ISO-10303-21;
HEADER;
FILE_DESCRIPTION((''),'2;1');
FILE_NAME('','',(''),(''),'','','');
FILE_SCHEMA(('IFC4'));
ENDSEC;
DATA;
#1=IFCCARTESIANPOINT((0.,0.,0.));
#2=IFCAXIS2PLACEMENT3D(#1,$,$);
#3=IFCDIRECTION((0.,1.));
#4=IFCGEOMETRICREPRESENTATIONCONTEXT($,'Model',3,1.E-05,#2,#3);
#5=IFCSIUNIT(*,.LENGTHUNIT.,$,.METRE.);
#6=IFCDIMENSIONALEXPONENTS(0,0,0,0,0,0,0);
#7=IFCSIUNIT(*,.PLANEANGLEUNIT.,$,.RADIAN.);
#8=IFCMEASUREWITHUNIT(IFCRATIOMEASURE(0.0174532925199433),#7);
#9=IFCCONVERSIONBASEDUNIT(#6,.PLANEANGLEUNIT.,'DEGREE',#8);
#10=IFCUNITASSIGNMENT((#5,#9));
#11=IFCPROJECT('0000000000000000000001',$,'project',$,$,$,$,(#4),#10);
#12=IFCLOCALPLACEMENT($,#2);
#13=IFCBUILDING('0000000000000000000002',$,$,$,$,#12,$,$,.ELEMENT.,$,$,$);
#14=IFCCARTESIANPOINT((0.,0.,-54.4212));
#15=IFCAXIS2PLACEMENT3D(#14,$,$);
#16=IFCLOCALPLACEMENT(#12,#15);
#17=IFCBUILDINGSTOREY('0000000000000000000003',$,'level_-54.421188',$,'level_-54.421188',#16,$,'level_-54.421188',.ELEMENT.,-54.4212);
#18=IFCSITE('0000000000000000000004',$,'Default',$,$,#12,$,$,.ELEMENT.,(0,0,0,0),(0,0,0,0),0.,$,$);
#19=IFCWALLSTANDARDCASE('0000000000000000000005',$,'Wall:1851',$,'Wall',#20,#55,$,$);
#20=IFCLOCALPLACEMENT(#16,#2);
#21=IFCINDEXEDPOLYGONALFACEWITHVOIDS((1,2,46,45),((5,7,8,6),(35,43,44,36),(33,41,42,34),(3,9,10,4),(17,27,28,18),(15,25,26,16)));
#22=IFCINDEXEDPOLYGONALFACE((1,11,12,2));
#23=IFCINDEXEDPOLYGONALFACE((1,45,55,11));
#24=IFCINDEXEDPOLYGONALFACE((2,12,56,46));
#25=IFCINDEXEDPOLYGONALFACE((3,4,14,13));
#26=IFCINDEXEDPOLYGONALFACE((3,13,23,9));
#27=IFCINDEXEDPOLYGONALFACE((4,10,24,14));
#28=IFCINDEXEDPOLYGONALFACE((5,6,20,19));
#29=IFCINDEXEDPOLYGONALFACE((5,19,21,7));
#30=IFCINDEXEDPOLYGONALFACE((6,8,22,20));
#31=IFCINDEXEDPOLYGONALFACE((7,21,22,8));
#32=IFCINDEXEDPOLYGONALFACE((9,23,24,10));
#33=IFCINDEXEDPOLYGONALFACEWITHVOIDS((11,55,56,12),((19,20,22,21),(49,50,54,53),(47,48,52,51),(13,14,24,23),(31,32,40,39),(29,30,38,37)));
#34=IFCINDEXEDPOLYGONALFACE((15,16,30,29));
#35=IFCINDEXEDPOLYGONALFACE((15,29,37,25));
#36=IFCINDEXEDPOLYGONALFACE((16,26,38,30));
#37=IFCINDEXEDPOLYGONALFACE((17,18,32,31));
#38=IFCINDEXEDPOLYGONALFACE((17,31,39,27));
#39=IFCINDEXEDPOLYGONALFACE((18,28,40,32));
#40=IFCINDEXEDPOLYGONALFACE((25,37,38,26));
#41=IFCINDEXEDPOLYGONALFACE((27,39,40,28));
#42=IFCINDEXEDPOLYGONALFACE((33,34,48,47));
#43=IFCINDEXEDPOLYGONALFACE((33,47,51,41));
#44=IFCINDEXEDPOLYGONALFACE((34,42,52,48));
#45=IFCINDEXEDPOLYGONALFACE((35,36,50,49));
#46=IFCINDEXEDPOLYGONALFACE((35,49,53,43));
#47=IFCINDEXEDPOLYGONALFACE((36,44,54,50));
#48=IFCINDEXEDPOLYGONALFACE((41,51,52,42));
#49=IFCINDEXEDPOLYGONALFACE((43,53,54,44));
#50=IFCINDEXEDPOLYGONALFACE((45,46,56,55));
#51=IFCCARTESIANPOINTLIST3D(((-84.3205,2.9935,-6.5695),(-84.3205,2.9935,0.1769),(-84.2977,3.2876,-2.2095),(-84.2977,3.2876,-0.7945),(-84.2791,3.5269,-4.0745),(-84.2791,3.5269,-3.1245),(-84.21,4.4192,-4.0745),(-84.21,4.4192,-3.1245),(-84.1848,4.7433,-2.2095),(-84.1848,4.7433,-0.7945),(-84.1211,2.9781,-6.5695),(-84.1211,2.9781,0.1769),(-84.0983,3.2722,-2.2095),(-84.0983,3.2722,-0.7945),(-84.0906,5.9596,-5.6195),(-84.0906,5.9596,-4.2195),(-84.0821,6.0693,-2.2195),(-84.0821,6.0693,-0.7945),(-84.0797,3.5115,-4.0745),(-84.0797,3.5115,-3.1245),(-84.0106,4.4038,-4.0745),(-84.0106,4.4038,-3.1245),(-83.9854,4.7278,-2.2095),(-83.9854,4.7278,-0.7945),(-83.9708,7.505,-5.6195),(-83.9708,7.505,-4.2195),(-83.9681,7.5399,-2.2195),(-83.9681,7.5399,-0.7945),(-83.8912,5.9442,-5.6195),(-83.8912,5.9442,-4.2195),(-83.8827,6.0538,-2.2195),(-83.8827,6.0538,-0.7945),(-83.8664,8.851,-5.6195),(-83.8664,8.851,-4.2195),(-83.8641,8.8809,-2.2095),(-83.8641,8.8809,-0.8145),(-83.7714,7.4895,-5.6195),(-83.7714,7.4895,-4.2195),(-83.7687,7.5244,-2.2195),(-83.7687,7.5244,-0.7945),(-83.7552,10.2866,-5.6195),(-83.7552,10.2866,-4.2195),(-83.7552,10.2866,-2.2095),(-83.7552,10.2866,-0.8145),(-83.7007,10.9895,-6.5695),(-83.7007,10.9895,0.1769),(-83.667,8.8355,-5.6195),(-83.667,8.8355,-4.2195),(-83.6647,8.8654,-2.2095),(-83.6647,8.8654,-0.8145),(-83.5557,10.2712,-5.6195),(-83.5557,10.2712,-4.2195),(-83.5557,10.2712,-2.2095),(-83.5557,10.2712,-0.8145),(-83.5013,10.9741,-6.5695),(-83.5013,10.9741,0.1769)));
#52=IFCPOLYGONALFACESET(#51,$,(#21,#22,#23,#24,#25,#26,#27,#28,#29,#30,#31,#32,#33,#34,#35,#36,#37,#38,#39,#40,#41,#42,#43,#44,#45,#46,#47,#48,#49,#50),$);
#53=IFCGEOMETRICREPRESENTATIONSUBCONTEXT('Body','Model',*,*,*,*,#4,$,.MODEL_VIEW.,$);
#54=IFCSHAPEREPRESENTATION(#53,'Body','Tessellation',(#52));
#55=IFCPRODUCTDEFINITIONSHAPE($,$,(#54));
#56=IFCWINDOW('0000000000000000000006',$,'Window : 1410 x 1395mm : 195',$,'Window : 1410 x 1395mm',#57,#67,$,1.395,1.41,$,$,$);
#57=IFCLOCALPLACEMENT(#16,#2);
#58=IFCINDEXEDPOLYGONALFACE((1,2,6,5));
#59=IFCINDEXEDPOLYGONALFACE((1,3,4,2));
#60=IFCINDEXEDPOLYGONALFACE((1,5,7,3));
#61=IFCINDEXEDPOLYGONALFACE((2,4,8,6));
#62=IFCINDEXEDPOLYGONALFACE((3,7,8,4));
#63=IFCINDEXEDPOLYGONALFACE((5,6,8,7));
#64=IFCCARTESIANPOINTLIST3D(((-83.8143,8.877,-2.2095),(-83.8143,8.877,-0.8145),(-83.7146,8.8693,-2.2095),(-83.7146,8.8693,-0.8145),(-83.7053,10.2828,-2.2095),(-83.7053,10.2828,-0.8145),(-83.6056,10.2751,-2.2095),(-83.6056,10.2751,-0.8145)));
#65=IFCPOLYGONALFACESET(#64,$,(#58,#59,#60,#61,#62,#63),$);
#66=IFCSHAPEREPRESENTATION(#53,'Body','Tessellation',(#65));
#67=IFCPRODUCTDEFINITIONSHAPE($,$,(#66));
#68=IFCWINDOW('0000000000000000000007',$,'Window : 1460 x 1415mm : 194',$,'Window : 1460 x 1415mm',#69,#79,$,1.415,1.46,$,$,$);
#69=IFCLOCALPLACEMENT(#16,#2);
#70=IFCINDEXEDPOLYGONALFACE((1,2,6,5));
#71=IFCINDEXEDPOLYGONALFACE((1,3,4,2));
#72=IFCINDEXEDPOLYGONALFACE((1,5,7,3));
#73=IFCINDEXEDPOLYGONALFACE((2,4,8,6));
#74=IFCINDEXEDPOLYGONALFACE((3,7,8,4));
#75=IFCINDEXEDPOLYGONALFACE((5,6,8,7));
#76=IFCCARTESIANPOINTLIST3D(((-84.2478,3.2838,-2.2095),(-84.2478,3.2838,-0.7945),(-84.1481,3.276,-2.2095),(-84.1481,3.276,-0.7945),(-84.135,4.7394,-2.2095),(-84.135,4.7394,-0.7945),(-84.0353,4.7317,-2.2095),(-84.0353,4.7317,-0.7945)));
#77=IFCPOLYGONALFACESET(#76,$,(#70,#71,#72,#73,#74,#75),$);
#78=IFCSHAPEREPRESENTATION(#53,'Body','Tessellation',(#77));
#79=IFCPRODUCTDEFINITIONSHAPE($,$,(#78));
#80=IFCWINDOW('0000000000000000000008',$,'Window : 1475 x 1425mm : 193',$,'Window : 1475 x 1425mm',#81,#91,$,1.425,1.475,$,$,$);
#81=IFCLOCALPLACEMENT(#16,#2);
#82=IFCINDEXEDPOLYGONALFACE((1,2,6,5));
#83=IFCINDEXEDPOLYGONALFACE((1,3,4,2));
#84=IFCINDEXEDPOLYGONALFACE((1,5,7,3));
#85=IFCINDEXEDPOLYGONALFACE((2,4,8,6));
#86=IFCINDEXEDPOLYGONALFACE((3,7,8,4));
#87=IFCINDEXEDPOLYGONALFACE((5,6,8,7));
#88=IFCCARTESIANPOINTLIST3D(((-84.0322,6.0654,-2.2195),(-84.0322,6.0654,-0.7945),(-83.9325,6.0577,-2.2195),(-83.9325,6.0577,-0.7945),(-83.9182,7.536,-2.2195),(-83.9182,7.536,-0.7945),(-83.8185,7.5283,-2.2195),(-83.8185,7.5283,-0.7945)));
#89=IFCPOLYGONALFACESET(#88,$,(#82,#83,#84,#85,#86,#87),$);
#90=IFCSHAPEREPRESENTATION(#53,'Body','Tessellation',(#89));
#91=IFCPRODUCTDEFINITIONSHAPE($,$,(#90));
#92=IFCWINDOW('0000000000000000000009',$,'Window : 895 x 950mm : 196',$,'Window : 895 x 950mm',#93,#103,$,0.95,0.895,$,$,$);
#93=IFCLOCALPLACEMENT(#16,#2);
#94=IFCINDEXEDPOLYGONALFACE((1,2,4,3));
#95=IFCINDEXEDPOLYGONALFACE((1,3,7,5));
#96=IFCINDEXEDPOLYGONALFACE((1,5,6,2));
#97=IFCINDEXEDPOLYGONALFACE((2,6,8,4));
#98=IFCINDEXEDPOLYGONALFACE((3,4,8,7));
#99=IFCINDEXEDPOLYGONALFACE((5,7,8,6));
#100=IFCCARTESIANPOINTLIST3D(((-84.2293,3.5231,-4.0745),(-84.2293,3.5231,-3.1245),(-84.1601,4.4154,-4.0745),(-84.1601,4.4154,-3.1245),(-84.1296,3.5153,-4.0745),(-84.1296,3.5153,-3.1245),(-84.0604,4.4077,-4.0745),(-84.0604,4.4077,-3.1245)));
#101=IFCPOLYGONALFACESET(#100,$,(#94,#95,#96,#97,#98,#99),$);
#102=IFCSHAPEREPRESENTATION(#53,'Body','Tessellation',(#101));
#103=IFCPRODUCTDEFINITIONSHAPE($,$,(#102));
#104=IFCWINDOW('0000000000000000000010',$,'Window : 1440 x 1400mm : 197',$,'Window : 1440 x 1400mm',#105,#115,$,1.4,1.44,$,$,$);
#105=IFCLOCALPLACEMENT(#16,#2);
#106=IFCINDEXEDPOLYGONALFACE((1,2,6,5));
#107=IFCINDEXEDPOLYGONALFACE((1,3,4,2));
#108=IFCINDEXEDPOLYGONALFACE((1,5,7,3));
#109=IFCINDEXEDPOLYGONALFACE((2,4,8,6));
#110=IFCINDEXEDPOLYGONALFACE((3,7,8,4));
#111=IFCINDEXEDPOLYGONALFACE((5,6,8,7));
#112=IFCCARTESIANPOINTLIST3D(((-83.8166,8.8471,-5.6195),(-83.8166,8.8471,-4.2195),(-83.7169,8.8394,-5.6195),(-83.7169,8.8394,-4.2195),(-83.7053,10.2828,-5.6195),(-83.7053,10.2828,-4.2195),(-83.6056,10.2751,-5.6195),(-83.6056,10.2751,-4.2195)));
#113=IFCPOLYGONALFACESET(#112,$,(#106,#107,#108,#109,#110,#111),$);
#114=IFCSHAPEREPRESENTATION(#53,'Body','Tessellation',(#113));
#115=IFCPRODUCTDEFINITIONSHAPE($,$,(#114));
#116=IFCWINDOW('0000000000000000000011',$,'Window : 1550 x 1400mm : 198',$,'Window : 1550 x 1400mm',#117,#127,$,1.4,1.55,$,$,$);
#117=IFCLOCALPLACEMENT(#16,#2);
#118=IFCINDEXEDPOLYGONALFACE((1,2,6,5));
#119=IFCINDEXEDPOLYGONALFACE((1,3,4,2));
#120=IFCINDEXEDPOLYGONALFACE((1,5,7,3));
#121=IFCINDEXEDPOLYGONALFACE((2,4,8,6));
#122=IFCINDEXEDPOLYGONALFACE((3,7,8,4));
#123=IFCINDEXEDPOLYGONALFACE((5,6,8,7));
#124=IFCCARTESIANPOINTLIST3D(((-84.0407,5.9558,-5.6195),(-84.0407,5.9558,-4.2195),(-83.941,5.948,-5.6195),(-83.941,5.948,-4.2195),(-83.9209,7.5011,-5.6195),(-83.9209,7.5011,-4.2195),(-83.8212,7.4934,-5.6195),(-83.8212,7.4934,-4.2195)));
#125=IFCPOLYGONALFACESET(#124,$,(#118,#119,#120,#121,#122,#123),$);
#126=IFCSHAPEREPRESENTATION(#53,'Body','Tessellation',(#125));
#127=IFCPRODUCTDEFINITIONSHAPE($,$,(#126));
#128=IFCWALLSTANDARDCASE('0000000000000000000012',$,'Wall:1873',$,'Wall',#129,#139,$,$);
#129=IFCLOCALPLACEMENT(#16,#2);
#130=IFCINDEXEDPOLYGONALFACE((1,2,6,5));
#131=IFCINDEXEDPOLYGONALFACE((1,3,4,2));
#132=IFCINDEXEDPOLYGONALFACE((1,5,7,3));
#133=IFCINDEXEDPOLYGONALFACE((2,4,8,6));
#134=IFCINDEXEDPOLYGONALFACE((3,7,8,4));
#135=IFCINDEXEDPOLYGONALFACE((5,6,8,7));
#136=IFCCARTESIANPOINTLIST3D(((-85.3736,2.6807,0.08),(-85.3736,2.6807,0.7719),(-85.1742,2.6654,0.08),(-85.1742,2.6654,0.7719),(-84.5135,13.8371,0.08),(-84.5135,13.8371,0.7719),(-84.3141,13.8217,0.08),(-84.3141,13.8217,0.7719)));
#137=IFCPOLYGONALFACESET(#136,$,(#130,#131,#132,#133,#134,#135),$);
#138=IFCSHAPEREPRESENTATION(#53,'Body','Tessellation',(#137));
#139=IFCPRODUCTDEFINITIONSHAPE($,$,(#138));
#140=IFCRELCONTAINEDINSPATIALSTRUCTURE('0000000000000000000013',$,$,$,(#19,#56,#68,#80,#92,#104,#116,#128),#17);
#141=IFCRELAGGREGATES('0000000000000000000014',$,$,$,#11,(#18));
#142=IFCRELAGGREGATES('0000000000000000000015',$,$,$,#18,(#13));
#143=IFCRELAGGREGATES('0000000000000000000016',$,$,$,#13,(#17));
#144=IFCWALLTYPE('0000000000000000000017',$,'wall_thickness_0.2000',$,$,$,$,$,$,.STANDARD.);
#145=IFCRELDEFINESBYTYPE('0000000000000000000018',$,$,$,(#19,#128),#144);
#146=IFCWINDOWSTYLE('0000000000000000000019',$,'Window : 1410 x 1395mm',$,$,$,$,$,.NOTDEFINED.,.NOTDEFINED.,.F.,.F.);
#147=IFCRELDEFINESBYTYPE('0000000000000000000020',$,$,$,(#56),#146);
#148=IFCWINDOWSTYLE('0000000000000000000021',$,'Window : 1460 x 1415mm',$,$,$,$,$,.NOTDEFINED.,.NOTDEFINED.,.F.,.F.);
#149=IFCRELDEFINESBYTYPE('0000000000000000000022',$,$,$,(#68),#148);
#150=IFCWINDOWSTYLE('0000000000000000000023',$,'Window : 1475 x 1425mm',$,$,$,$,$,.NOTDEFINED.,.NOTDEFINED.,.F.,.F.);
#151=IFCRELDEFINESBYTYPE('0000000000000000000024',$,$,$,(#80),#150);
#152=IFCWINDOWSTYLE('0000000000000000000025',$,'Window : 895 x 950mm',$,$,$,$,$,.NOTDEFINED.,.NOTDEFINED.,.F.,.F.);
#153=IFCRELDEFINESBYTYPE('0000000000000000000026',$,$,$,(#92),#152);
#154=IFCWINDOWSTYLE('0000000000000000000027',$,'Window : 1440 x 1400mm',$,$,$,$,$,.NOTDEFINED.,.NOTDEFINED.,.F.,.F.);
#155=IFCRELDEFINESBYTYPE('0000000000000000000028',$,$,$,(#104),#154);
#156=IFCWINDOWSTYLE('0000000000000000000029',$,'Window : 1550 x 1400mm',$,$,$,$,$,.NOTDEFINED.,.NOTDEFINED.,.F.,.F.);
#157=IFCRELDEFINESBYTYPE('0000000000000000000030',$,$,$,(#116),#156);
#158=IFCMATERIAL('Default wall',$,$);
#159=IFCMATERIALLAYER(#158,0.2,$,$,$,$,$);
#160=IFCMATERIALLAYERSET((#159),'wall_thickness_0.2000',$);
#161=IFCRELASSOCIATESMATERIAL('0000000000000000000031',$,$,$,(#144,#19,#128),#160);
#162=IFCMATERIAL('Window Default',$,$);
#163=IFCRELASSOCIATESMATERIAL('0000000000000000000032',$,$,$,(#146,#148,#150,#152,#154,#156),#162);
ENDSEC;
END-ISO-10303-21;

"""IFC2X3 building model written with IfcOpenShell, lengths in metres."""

from ifc_helpers import new_model, entity, si_unit, converted_unit, direction, frame, frame_2d, origin, origin_2d_with_axis, place, context, subcontext, project, spatial, polyline, rectangle, outline, extrude, source, transform, mapped, material, layer, layer_set, layer_usage, type_object, type_shapes, element, fill, save


model = new_model("IFC2X3")

# Units and contexts
model_context = context("Model", 3, precision=1e-05, world=origin(), true_north=direction((0.0, 1.0)))
body_context = subcontext(model_context, "Body", "Model", "MODEL_VIEW")
ifc_project = project(units=[si_unit("LENGTHUNIT", "METRE"), converted_unit("PLANEANGLEUNIT", "DEGREE", entity("IfcRatioMeasure", 0.0174532925199433), si_unit("PLANEANGLEUNIT", "RADIAN"), dimensions=[0, 0, 0, 0, 0, 0, 0])], contexts=[model_context])

# Site, building, storey
placement_1 = place(None, origin())
site = spatial("IfcSite", under=ifc_project, at=placement_1, Name="Default", CompositionType="ELEMENT", RefLatitude=(0, 0, 0, 0), RefLongitude=(0, 0, 0, 0), RefElevation=0.0)
building = spatial("IfcBuilding", under=site, at=placement_1, CompositionType="ELEMENT")
storey_placement = place(placement_1, frame((0.0, 0.0, -54.4212)))
storey = spatial("IfcBuildingStorey", under=building, at=storey_placement, Name="level_-54.421188", ObjectType="level_-54.421188", LongName="level_-54.421188", CompositionType="ELEMENT", Elevation=-54.4212)

# Shared definitions
ifc_material_1 = material(Name="Default wall")
ifc_layer = layer(ifc_material_1, 0.2)
ifc_layer_set = layer_set([ifc_layer], Name="wall_thickness_0.2000")
ifc_layer_usage = layer_usage(ifc_layer_set, "AXIS2", "POSITIVE", -0.1)
wall_type = type_object("IfcWallType", Name="wall_thickness_0.2000", PredefinedType="STANDARD", material=ifc_layer_set)

# Wall, openings, windows
placement_2 = place(placement_1, frame((0.0, 0.0, -60.9907)))
wall_1_placement = place(placement_2, frame((-83.601, 10.9818, 0.0), z_axis=(0.0, 0.0, 1.0), x_axis=(-0.077281, -0.997009, 0.0)))
wall_1 = element("IfcWallStandardCase", 1, at=wall_1_placement, inside=storey, type_object=wall_type, material=ifc_layer_usage, Name="Wall:1851", ObjectType="Wall", context=body_context, shape_type="SweptSolid", body=[
    extrude(outline(polyline([(8.02, -0.1), (8.02, 0.1), (0.0, 0.1), (0.0, -0.1), (8.02, -0.1)])), origin(), (0.0, 0.0, 1.0), 6.7464),
])
opening_1_placement = place(wall_1_placement, frame((3.46, -0.1, 4.3499)))
opening_1 = element("IfcOpeningElement", 2, at=opening_1_placement, cuts=wall_1, ObjectType="Opening", context=body_context, shape_type="SweptSolid", body=[
    extrude(rectangle(XDim=1.475, YDim=1.425, at=frame_2d((0.7125, 0.7375), x_axis=(0.0, 1.0))), frame((0.0, 0.0, 0.0), z_axis=(0.0, 1.0, 0.0), x_axis=(0.0, 0.0, 1.0)), (0.0, 0.0, 1.0), 0.2),
])
opening_2_placement = place(wall_1_placement, frame((6.265, -0.1, 4.3599)))
opening_2 = element("IfcOpeningElement", 3, at=opening_2_placement, cuts=wall_1, ObjectType="Opening", context=body_context, shape_type="SweptSolid", body=[
    extrude(rectangle(XDim=1.46, YDim=1.415, at=frame_2d((0.7075, 0.73), x_axis=(0.0, 1.0))), frame((0.0, 0.0, 0.0), z_axis=(0.0, 1.0, 0.0), x_axis=(0.0, 0.0, 1.0)), (0.0, 0.0, 1.0), 0.2),
])
opening_3_placement = place(wall_1_placement, frame((0.705, -0.1, 4.3599)))
opening_3 = element("IfcOpeningElement", 4, at=opening_3_placement, cuts=wall_1, ObjectType="Opening", context=body_context, shape_type="SweptSolid", body=[
    extrude(rectangle(XDim=1.41, YDim=1.395, at=frame_2d((0.6975, 0.705), x_axis=(0.0, 1.0))), frame((0.0, 0.0, 0.0), z_axis=(0.0, 1.0, 0.0), x_axis=(0.0, 0.0, 1.0)), (0.0, 0.0, 1.0), 0.2),
])
opening_4_placement = place(wall_1_placement, frame((6.59, -0.1, 2.4949)))
opening_4 = element("IfcOpeningElement", 5, at=opening_4_placement, cuts=wall_1, ObjectType="Opening", context=body_context, shape_type="SweptSolid", body=[
    extrude(rectangle(XDim=0.895, YDim=0.95, at=frame_2d((0.475, 0.4475), x_axis=(0.0, 1.0))), frame((0.0, 0.0, 0.0), z_axis=(0.0, 1.0, 0.0), x_axis=(0.0, 0.0, 1.0)), (0.0, 0.0, 1.0), 0.2),
])
opening_5_placement = place(wall_1_placement, frame((0.705, -0.1, 0.9499)))
opening_5 = element("IfcOpeningElement", 6, at=opening_5_placement, cuts=wall_1, ObjectType="Opening", context=body_context, shape_type="SweptSolid", body=[
    extrude(rectangle(XDim=1.44, YDim=1.4, at=frame_2d((0.7, 0.72), x_axis=(0.0, 1.0))), frame((0.0, 0.0, 0.0), z_axis=(0.0, 1.0, 0.0), x_axis=(0.0, 0.0, 1.0)), (0.0, 0.0, 1.0), 0.2),
])
opening_6_placement = place(wall_1_placement, frame((3.495, -0.1, 0.9499)))
opening_6 = element("IfcOpeningElement", 7, at=opening_6_placement, cuts=wall_1, ObjectType="Opening", context=body_context, shape_type="SweptSolid", body=[
    extrude(rectangle(XDim=1.55, YDim=1.4, at=frame_2d((0.7, 0.775), x_axis=(0.0, 1.0))), frame((0.0, 0.0, 0.0), z_axis=(0.0, 1.0, 0.0), x_axis=(0.0, 0.0, 1.0)), (0.0, 0.0, 1.0), 0.2),
])
ifc_material_2 = material(Name="Window Default")
window_style_1 = type_object("IfcWindowStyle", Name="Window : 1410 x 1395mm", ConstructionType="NOTDEFINED", OperationType="NOTDEFINED", ParameterTakesPrecedence=False, Sizeable=False, material=ifc_material_2)
shared_shape_1 = source(origin(), body_context, "Body", "SweptSolid", [
    extrude(rectangle(XDim=0.1, YDim=1.41, at=origin_2d_with_axis()), frame((0.705, 0.1, 0.0), z_axis=(0.0, 0.0, 1.0), x_axis=(0.0, 1.0, 0.0)), (0.0, 0.0, 1.0), 1.395),
])
type_shapes(window_style_1, [shared_shape_1])
window_1_placement = place(opening_3_placement, origin())
window_1 = element("IfcWindow", 8, at=window_1_placement, inside=storey, type_object=window_style_1, Name="Window : 1410 x 1395mm : 195", ObjectType="Window : 1410 x 1395mm", OverallHeight=1.395, OverallWidth=1.41, context=body_context, shape_type="MappedRepresentation", body=[
    mapped(shared_shape_1, transform((0.0, 0.0, 0.0), scale=1.0)),
])
fill(opening_3, window_1)
window_style_2 = type_object("IfcWindowStyle", Name="Window : 1460 x 1415mm", ConstructionType="NOTDEFINED", OperationType="NOTDEFINED", ParameterTakesPrecedence=False, Sizeable=False, material=ifc_material_2)
shared_shape_2 = source(origin(), body_context, "Body", "SweptSolid", [
    extrude(rectangle(XDim=0.1, YDim=1.46, at=origin_2d_with_axis()), frame((0.73, 0.1, 0.0), z_axis=(0.0, 0.0, 1.0), x_axis=(0.0, 1.0, 0.0)), (0.0, 0.0, 1.0), 1.415),
])
type_shapes(window_style_2, [shared_shape_2])
window_2_placement = place(opening_2_placement, origin())
window_2 = element("IfcWindow", 9, at=window_2_placement, inside=storey, type_object=window_style_2, Name="Window : 1460 x 1415mm : 194", ObjectType="Window : 1460 x 1415mm", OverallHeight=1.415, OverallWidth=1.46, context=body_context, shape_type="MappedRepresentation", body=[
    mapped(shared_shape_2, transform((0.0, 0.0, 0.0), scale=1.0)),
])
fill(opening_2, window_2)
window_style_3 = type_object("IfcWindowStyle", Name="Window : 1475 x 1425mm", ConstructionType="NOTDEFINED", OperationType="NOTDEFINED", ParameterTakesPrecedence=False, Sizeable=False, material=ifc_material_2)
shared_shape_3 = source(origin(), body_context, "Body", "SweptSolid", [
    extrude(rectangle(XDim=0.1, YDim=1.475, at=origin_2d_with_axis()), frame((0.7375, 0.1, 0.0), z_axis=(0.0, 0.0, 1.0), x_axis=(0.0, 1.0, 0.0)), (0.0, 0.0, 1.0), 1.425),
])
type_shapes(window_style_3, [shared_shape_3])
window_3_placement = place(opening_1_placement, origin())
window_3 = element("IfcWindow", 10, at=window_3_placement, inside=storey, type_object=window_style_3, Name="Window : 1475 x 1425mm : 193", ObjectType="Window : 1475 x 1425mm", OverallHeight=1.425, OverallWidth=1.475, context=body_context, shape_type="MappedRepresentation", body=[
    mapped(shared_shape_3, transform((0.0, 0.0, 0.0), scale=1.0)),
])
fill(opening_1, window_3)
window_style_4 = type_object("IfcWindowStyle", Name="Window : 895 x 950mm", ConstructionType="NOTDEFINED", OperationType="NOTDEFINED", ParameterTakesPrecedence=False, Sizeable=False, material=ifc_material_2)
shared_shape_4 = source(origin(), body_context, "Body", "SweptSolid", [
    extrude(rectangle(XDim=0.1, YDim=0.895, at=origin_2d_with_axis()), frame((0.4475, 0.1, 0.0), z_axis=(0.0, 0.0, 1.0), x_axis=(0.0, 1.0, 0.0)), (0.0, 0.0, 1.0), 0.95),
])
type_shapes(window_style_4, [shared_shape_4])
window_4_placement = place(opening_4_placement, origin())
window_4 = element("IfcWindow", 11, at=window_4_placement, inside=storey, type_object=window_style_4, Name="Window : 895 x 950mm : 196", ObjectType="Window : 895 x 950mm", OverallHeight=0.95, OverallWidth=0.895, context=body_context, shape_type="MappedRepresentation", body=[
    mapped(shared_shape_4, transform((0.0, 0.0, 0.0), scale=1.0)),
])
fill(opening_4, window_4)
window_style_5 = type_object("IfcWindowStyle", Name="Window : 1440 x 1400mm", ConstructionType="NOTDEFINED", OperationType="NOTDEFINED", ParameterTakesPrecedence=False, Sizeable=False, material=ifc_material_2)
shared_shape_5 = source(origin(), body_context, "Body", "SweptSolid", [
    extrude(rectangle(XDim=0.1, YDim=1.44, at=origin_2d_with_axis()), frame((0.72, 0.1, 0.0), z_axis=(0.0, 0.0, 1.0), x_axis=(0.0, 1.0, 0.0)), (0.0, 0.0, 1.0), 1.4),
])
type_shapes(window_style_5, [shared_shape_5])
window_5_placement = place(opening_5_placement, origin())
window_5 = element("IfcWindow", 12, at=window_5_placement, inside=storey, type_object=window_style_5, Name="Window : 1440 x 1400mm : 197", ObjectType="Window : 1440 x 1400mm", OverallHeight=1.4, OverallWidth=1.44, context=body_context, shape_type="MappedRepresentation", body=[
    mapped(shared_shape_5, transform((0.0, 0.0, 0.0), scale=1.0)),
])
fill(opening_5, window_5)
window_style_6 = type_object("IfcWindowStyle", Name="Window : 1550 x 1400mm", ConstructionType="NOTDEFINED", OperationType="NOTDEFINED", ParameterTakesPrecedence=False, Sizeable=False, material=ifc_material_2)
shared_shape_6 = source(origin(), body_context, "Body", "SweptSolid", [
    extrude(rectangle(XDim=0.1, YDim=1.55, at=origin_2d_with_axis()), frame((0.775, 0.1, 0.0), z_axis=(0.0, 0.0, 1.0), x_axis=(0.0, 1.0, 0.0)), (0.0, 0.0, 1.0), 1.4),
])
type_shapes(window_style_6, [shared_shape_6])
window_6_placement = place(opening_6_placement, origin())
window_6 = element("IfcWindow", 13, at=window_6_placement, inside=storey, type_object=window_style_6, Name="Window : 1550 x 1400mm : 198", ObjectType="Window : 1550 x 1400mm", OverallHeight=1.4, OverallWidth=1.55, context=body_context, shape_type="MappedRepresentation", body=[
    mapped(shared_shape_6, transform((0.0, 0.0, 0.0), scale=1.0)),
])
fill(opening_6, window_6)

# Wall
placement_3 = place(placement_1, frame((0.0, 0.0, -54.3412)))
wall_2_placement = place(placement_3, frame((-85.2739, 2.6731, 0.0), z_axis=(0.0, 0.0, 1.0), x_axis=(0.076866, 0.997041, 0.0)))
element("IfcWallStandardCase", 14, at=wall_2_placement, inside=storey, type_object=wall_type, material=ifc_layer_usage, Name="Wall:1873", ObjectType="Wall", context=body_context, shape_type="SweptSolid", body=[
    extrude(outline(polyline([(11.1894, -0.1), (11.1894, 0.1), (0.0, 0.1), (0.0, -0.1), (11.1894, -0.1)])), origin(), (0.0, 0.0, 1.0), 0.692),
])

save(model, "model.ifc")
